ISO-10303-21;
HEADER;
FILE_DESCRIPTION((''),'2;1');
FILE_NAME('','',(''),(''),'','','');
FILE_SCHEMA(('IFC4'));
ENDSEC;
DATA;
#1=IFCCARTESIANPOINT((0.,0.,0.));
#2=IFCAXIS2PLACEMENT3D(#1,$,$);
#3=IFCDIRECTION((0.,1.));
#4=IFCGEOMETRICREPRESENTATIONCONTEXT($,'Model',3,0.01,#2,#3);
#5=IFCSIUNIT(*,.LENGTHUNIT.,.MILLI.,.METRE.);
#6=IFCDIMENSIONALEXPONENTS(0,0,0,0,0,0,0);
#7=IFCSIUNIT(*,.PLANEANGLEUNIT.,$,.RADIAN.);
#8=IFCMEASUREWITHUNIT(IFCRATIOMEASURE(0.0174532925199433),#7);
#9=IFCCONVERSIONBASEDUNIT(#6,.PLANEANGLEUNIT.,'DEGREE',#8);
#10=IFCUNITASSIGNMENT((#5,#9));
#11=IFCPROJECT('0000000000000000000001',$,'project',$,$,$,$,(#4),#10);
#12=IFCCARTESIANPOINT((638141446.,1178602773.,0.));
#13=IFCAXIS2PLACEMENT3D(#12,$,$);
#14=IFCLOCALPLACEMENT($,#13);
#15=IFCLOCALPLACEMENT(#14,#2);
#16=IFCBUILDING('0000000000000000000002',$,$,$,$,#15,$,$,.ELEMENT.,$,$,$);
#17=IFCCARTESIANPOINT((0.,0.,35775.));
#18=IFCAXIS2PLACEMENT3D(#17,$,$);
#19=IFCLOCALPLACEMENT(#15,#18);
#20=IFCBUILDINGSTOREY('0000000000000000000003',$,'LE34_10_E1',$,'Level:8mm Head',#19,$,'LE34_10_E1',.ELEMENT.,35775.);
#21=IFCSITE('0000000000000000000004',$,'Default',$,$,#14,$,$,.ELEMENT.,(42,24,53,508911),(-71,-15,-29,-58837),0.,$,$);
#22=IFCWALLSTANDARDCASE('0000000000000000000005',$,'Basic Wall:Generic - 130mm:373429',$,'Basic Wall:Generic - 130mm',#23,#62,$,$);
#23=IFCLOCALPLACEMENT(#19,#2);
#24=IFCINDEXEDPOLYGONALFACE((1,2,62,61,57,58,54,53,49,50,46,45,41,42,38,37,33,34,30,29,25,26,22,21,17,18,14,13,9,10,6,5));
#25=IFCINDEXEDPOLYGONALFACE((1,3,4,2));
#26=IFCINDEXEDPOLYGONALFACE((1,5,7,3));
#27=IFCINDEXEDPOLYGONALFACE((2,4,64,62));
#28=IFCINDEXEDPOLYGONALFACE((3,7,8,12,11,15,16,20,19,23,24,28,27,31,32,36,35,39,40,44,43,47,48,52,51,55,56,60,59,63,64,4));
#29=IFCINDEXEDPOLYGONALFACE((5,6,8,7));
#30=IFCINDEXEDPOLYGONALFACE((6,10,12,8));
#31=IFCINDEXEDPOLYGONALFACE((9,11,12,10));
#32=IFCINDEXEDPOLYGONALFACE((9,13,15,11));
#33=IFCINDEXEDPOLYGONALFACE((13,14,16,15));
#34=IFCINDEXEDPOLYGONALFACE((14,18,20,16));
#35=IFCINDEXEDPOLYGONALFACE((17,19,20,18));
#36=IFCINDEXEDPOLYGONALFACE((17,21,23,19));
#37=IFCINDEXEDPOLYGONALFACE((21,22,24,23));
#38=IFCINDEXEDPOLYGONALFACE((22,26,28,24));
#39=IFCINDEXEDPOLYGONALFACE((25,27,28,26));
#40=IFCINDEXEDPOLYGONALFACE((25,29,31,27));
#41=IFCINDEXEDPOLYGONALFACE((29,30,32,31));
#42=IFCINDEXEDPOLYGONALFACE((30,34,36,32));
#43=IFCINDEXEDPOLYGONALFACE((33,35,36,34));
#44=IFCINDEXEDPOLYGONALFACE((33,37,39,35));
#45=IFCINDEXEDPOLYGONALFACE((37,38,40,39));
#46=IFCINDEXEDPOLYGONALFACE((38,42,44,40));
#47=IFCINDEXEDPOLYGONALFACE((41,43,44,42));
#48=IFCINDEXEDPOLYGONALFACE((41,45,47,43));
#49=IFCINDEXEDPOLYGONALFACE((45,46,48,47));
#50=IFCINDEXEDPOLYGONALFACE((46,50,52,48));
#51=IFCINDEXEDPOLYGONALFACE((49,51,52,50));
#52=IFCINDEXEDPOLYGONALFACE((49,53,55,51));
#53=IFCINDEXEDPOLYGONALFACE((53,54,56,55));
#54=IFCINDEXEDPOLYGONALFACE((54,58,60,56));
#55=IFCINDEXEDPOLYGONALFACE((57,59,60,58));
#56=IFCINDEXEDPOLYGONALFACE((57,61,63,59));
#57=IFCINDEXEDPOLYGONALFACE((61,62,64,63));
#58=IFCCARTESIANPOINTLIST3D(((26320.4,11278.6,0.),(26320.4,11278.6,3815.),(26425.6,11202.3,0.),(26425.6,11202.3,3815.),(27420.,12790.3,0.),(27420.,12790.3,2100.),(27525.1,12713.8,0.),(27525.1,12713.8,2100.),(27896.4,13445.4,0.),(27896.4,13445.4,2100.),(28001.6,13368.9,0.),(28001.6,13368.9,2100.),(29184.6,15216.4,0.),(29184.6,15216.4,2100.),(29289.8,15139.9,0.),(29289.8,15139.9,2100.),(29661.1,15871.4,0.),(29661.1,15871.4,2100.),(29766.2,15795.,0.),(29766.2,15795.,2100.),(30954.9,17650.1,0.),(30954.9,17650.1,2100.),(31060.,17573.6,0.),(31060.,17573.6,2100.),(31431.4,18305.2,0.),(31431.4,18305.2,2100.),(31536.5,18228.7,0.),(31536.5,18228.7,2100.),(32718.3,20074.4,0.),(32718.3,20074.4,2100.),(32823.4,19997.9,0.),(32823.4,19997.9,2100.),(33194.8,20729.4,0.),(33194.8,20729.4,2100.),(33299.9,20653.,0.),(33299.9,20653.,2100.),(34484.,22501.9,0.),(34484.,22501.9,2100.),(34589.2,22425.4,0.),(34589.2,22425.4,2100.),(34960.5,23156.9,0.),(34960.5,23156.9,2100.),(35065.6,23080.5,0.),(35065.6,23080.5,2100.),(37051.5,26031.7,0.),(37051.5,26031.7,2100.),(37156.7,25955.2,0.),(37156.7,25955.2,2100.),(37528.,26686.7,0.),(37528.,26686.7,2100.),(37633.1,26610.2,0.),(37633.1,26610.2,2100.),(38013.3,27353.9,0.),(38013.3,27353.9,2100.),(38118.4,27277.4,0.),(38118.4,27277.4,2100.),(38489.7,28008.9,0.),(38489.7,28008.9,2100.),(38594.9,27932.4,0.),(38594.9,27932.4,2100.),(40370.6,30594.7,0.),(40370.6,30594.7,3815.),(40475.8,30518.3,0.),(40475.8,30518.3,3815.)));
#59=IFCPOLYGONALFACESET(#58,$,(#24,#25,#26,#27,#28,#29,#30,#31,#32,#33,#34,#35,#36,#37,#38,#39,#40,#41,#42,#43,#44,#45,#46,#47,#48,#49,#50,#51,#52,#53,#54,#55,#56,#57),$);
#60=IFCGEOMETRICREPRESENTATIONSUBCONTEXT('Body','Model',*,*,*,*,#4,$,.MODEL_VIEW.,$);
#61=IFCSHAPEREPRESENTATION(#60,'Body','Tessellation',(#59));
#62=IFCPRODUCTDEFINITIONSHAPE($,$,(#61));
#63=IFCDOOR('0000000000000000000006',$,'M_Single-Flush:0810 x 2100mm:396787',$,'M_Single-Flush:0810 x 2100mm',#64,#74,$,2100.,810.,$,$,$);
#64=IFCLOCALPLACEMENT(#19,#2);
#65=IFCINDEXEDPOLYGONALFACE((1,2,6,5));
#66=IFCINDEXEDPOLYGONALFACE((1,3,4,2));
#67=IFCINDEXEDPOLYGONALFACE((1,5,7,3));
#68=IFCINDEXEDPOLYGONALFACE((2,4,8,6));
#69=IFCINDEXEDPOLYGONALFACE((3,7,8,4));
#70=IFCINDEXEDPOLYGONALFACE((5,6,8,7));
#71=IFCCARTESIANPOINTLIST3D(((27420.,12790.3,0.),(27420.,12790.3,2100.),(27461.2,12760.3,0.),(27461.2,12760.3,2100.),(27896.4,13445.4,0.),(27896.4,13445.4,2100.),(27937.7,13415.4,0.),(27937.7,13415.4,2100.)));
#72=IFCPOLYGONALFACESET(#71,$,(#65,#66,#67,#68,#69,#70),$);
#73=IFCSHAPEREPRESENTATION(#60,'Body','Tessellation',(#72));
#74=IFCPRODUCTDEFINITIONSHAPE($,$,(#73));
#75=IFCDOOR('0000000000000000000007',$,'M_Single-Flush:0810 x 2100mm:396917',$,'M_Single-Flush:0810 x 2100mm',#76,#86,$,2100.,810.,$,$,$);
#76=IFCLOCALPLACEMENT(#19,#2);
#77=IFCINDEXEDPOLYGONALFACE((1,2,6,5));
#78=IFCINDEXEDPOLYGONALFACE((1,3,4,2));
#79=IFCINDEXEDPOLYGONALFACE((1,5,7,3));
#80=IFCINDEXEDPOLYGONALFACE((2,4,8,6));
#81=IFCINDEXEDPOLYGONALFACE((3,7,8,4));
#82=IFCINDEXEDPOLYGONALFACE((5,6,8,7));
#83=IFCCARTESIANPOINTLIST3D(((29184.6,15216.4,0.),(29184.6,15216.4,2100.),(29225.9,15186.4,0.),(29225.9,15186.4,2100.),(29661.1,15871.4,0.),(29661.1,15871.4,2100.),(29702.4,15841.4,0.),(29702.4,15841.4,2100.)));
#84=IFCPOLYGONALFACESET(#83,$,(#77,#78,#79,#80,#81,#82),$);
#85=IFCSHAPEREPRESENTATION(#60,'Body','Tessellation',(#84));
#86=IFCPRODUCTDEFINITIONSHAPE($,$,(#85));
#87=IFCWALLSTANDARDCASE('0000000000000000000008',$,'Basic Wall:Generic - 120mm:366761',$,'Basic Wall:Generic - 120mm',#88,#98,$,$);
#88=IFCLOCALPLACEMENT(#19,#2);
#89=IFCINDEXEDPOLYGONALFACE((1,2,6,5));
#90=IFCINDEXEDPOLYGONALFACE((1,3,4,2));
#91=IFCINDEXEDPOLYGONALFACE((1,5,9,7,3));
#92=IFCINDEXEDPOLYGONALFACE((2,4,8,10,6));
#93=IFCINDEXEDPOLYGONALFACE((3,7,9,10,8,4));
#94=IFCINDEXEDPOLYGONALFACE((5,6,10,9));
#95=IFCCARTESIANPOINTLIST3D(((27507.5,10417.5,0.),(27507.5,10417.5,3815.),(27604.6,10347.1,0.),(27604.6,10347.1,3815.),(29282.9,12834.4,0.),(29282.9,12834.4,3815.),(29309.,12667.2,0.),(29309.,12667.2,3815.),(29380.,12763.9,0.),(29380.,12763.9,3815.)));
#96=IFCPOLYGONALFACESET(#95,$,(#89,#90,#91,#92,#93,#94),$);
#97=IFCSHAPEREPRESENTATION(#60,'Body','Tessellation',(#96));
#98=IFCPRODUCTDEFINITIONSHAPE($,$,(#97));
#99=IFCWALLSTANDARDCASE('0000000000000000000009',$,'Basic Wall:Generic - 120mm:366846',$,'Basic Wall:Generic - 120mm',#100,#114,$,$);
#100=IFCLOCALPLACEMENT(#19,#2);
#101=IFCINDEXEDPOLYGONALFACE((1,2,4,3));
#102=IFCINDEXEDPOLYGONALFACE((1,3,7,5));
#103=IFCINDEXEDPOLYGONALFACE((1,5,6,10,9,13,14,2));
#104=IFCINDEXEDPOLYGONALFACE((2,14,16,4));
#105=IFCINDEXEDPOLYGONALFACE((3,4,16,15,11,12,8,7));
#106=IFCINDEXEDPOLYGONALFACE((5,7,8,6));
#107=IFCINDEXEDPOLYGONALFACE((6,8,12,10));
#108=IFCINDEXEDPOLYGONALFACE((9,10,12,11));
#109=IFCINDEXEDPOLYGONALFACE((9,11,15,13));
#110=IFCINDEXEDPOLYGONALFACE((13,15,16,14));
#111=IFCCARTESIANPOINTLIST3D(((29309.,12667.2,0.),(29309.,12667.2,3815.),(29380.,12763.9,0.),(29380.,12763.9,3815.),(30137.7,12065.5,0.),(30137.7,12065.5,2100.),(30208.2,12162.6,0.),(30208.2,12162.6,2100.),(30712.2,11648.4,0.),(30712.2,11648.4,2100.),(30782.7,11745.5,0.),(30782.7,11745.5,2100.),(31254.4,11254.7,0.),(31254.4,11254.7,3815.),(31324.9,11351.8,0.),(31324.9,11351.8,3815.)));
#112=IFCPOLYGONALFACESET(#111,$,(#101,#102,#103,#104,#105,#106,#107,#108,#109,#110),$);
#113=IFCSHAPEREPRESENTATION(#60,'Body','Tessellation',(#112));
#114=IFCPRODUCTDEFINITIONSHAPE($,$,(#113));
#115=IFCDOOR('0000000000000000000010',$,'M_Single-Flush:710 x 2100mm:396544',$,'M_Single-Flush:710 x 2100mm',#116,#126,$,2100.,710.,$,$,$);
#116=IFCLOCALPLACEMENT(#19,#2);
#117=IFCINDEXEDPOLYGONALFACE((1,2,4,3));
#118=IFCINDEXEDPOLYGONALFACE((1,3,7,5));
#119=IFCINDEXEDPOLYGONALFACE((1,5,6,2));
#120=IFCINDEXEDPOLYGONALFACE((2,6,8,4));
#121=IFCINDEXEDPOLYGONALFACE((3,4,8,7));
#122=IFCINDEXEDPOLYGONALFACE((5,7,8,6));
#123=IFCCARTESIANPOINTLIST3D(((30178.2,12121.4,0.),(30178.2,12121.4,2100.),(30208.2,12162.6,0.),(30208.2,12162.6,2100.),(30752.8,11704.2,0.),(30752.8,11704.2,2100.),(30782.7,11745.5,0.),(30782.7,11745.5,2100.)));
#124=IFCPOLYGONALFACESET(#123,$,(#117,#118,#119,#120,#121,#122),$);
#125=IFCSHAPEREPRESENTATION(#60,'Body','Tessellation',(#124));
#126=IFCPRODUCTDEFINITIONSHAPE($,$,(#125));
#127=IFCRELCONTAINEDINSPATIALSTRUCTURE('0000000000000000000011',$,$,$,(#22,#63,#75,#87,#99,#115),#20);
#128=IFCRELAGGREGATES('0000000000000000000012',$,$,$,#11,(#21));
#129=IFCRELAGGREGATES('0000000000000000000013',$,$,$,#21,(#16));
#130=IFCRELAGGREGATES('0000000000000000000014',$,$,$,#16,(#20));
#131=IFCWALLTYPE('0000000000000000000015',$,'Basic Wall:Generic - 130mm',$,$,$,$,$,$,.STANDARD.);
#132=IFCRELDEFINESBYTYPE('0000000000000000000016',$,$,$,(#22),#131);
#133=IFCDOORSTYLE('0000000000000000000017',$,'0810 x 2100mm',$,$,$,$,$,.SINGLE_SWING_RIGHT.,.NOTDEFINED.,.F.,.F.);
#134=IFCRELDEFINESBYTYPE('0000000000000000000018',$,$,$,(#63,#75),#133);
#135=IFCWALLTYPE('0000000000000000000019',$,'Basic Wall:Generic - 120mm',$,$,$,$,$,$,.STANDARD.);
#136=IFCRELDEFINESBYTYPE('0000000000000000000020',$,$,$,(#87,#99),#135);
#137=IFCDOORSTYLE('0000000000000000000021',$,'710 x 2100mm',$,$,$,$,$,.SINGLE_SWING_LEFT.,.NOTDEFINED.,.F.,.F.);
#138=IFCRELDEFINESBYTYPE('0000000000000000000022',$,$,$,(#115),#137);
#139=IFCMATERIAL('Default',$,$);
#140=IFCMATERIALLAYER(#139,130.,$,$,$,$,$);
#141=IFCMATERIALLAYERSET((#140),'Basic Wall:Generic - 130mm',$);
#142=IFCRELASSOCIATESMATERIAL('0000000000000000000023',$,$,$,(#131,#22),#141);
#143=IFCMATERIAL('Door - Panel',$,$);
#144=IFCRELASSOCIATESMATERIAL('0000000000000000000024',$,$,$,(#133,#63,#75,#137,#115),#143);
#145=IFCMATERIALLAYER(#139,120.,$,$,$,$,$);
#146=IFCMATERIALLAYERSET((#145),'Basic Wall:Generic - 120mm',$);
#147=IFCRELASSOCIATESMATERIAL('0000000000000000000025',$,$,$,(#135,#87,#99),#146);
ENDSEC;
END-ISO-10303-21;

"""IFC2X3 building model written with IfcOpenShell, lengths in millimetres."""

from ifc_helpers import new_model, entity, si_unit, converted_unit, direction, frame, frame_2d, origin, place, context, subcontext, project, spatial, polyline, rectangle, outline, extrude, source, transform, mapped, material, layer, layer_set, layer_usage, type_object, type_shapes, element, fill, save


model = new_model("IFC2X3")

# Units and contexts
model_context = context("Model", 3, precision=0.01, world=origin(), true_north=direction((0.0, 1.0)))
body_context = subcontext(model_context, "Body", "Model", "MODEL_VIEW")
ifc_project = project(units=[si_unit("LENGTHUNIT", "METRE", prefix="MILLI"), converted_unit("PLANEANGLEUNIT", "DEGREE", entity("IfcRatioMeasure", 0.0174532925199433), si_unit("PLANEANGLEUNIT", "RADIAN"), dimensions=[0, 0, 0, 0, 0, 0, 0])], contexts=[model_context])

# Site, building, storey
site_placement = place(None, frame((638141446.0, 1178602773.0, 0.0)))
site = spatial("IfcSite", under=ifc_project, at=site_placement, Name="Default", CompositionType="ELEMENT", RefLatitude=(42, 24, 53, 508911), RefLongitude=(-71, -15, -29, -58837), RefElevation=0.0)
building_placement = place(site_placement, origin())
building = spatial("IfcBuilding", under=site, at=building_placement, CompositionType="ELEMENT")
storey_placement = place(building_placement, frame((0.0, 0.0, 35775.0)))
storey = spatial("IfcBuildingStorey", under=building, at=storey_placement, Name="LE34_10_E1", ObjectType="Level:8mm Head", LongName="LE34_10_E1", CompositionType="ELEMENT", Elevation=35775.0)

# Shared definitions
ifc_material_1 = material(Name="Default")
ifc_material_2 = material(Name="Door - Panel")

# Wall, openings, doors
ifc_layer_1 = layer(ifc_material_1, 130.0)
ifc_layer_set_1 = layer_set([ifc_layer_1], Name="Basic Wall:Generic - 130mm")
ifc_layer_usage_1 = layer_usage(ifc_layer_set_1, "AXIS2", "NEGATIVE", 65.0)
wall_type_1 = type_object("IfcWallType", Name="Basic Wall:Generic - 130mm", PredefinedType="STANDARD", material=ifc_layer_set_1)
wall_1_placement = place(storey_placement, frame((26372.9, 11240.4, 0.0), z_axis=(0.0, 0.0, 1.0), x_axis=(0.588231, 0.808693, 0.0)))
wall_1 = element("IfcWallStandardCase", 1, at=wall_1_placement, inside=storey, type_object=wall_type_1, material=ifc_layer_usage_1, Name="Basic Wall:Generic - 130mm:373429", ObjectType="Basic Wall:Generic - 130mm", context=body_context, shape_type="SweptSolid", body=[
    extrude(outline(polyline([(0.2, -65.0), (23885.6, -65.0), (23885.6, 65.0), (5999.3, 65.0), (5879.3, 65.0), (0.0, 65.0), (0.2, -65.0)])), origin(), (0.0, 0.0, 1.0), 3815.0),
])
opening_1_placement = place(wall_1_placement, frame((1869.3, -65.0, 0.0)))
opening_1 = element("IfcOpeningElement", 2, at=opening_1_placement, cuts=wall_1, ObjectType="Opening", context=body_context, shape_type="SweptSolid", body=[
    extrude(rectangle(XDim=810.0, YDim=2100.0, at=frame_2d((1050.0, 405.0), x_axis=(0.0, 1.0))), frame((0.0, 0.0, 0.0), z_axis=(0.0, 1.0, 0.0), x_axis=(0.0, 0.0, 1.0)), (0.0, 0.0, 1.0), 130.0),
])
opening_2_placement = place(wall_1_placement, frame((4869.3, -65.0, 0.0)))
opening_2 = element("IfcOpeningElement", 3, at=opening_2_placement, cuts=wall_1, ObjectType="Opening", context=body_context, shape_type="SweptSolid", body=[
    extrude(rectangle(XDim=810.0, YDim=2100.0, at=frame_2d((1050.0, 405.0), x_axis=(0.0, 1.0))), frame((0.0, 0.0, 0.0), z_axis=(0.0, 1.0, 0.0), x_axis=(0.0, 0.0, 1.0)), (0.0, 0.0, 1.0), 130.0),
])
opening_3_placement = place(wall_1_placement, frame((-24603.4, 14715.7, 0.0), z_axis=(0.0, 0.0, 1.0), x_axis=(0.588231, -0.808693, 0.0)))
element("IfcOpeningElement", 4, at=opening_3_placement, cuts=wall_1, ObjectType="Opening", context=body_context, shape_type="SweptSolid", body=[
    extrude(rectangle(XDim=2100.0, YDim=810.0, at=frame_2d((0.0, 0.0), x_axis=(1.0, 0.0))), frame((32530.7, 17004.7, 1050.0), z_axis=(-0.808693, 0.588231, 0.0), x_axis=(0.0, 0.0, 1.0)), (0.0, 0.0, 1.0), 3048.0),
])
opening_4_placement = place(wall_1_placement, frame((-24603.4, 14715.7, 0.0), z_axis=(0.0, 0.0, 1.0), x_axis=(0.588231, -0.808693, 0.0)))
element("IfcOpeningElement", 5, at=opening_4_placement, cuts=wall_1, ObjectType="Opening", context=body_context, shape_type="SweptSolid", body=[
    extrude(rectangle(XDim=2100.0, YDim=810.0, at=frame_2d((0.0, 0.0), x_axis=(1.0, 0.0))), frame((34294.1, 19429.0, 1050.0), z_axis=(-0.808693, 0.588231, 0.0), x_axis=(0.0, 0.0, 1.0)), (0.0, 0.0, 1.0), 3048.0),
])
opening_5_placement = place(wall_1_placement, frame((-24603.4, 14715.7, 0.0), z_axis=(0.0, 0.0, 1.0), x_axis=(0.588231, -0.808693, 0.0)))
element("IfcOpeningElement", 6, at=opening_5_placement, cuts=wall_1, ObjectType="Opening", context=body_context, shape_type="SweptSolid", body=[
    extrude(rectangle(XDim=2100.0, YDim=810.0, at=frame_2d((0.0, 0.0), x_axis=(1.0, 0.0))), frame((36059.8, 21856.5, 1050.0), z_axis=(-0.808693, 0.588231, 0.0), x_axis=(0.0, 0.0, 1.0)), (0.0, 0.0, 1.0), 3048.0),
])
opening_6_placement = place(wall_1_placement, frame((-24603.4, 14715.7, 0.0), z_axis=(0.0, 0.0, 1.0), x_axis=(0.588231, -0.808693, 0.0)))
element("IfcOpeningElement", 7, at=opening_6_placement, cuts=wall_1, ObjectType="Opening", context=body_context, shape_type="SweptSolid", body=[
    extrude(rectangle(XDim=2100.0, YDim=810.0, at=frame_2d((0.0, 0.0), x_axis=(1.0, 0.0))), frame((38627.3, 25386.2, 1050.0), z_axis=(-0.808693, 0.588231, 0.0), x_axis=(0.0, 0.0, 1.0)), (0.0, 0.0, 1.0), 3048.0),
])
opening_7_placement = place(wall_1_placement, frame((-24603.4, 14715.7, 0.0), z_axis=(0.0, 0.0, 1.0), x_axis=(0.588231, -0.808693, 0.0)))
element("IfcOpeningElement", 8, at=opening_7_placement, cuts=wall_1, ObjectType="Opening", context=body_context, shape_type="SweptSolid", body=[
    extrude(rectangle(XDim=2100.0, YDim=810.0, at=frame_2d((0.0, 0.0), x_axis=(0.0, 1.0))), frame((39589.1, 26708.5, 1050.0), z_axis=(-0.808693, 0.588231, 0.0), x_axis=(-0.588231, -0.808693, 0.0)), (0.0, 0.0, 1.0), 3048.0),
])
door_style_1 = type_object("IfcDoorStyle", Name="0810 x 2100mm", ConstructionType="NOTDEFINED", OperationType="SINGLE_SWING_RIGHT", ParameterTakesPrecedence=False, Sizeable=False, material=ifc_material_2)
shared_shape_1 = source(origin(), body_context, "Body", "SweptSolid", [
    extrude(rectangle(XDim=51.0, YDim=810.0, at=frame_2d((0.0, 0.0), x_axis=(1.0, 0.0))), frame((405.0, 104.5, 0.0), z_axis=(0.0, 0.0, 1.0), x_axis=(0.0, 1.0, 0.0)), (0.0, 0.0, 1.0), 2100.0),
])
type_shapes(door_style_1, [shared_shape_1])
door_1_placement = place(opening_1_placement, origin())
door_1 = element("IfcDoor", 9, at=door_1_placement, inside=storey, type_object=door_style_1, material=ifc_material_2, Name="M_Single-Flush:0810 x 2100mm:396787", ObjectType="M_Single-Flush:0810 x 2100mm", OverallHeight=2100.0, OverallWidth=810.0, context=body_context, shape_type="MappedRepresentation", body=[
    mapped(shared_shape_1, transform((0.0, 0.0, 0.0), scale=1.0)),
])
fill(opening_1, door_1)
door_2_placement = place(opening_2_placement, origin())
door_2 = element("IfcDoor", 10, at=door_2_placement, inside=storey, type_object=door_style_1, material=ifc_material_2, Name="M_Single-Flush:0810 x 2100mm:396917", ObjectType="M_Single-Flush:0810 x 2100mm", OverallHeight=2100.0, OverallWidth=810.0, context=body_context, shape_type="MappedRepresentation", body=[
    mapped(shared_shape_1, transform((0.0, 0.0, 0.0), scale=1.0)),
])
fill(opening_2, door_2)

# Wall
ifc_layer_2 = layer(ifc_material_1, 120.0)
ifc_layer_set_2 = layer_set([ifc_layer_2], Name="Basic Wall:Generic - 120mm")
ifc_layer_usage_2 = layer_usage(ifc_layer_set_2, "AXIS2", "NEGATIVE", 60.0)
wall_type_2 = type_object("IfcWallType", Name="Basic Wall:Generic - 120mm", PredefinedType="STANDARD", material=ifc_layer_set_2)
wall_2_placement = place(storey_placement, frame((27555.8, 10382.0, 0.0), z_axis=(0.0, 0.0, 1.0), x_axis=(0.592029, 0.805916, 0.0)))
element("IfcWallStandardCase", 11, at=wall_2_placement, inside=storey, type_object=wall_type_2, material=ifc_layer_usage_2, Name="Basic Wall:Generic - 120mm:366761", ObjectType="Basic Wall:Generic - 120mm", context=body_context, shape_type="SweptSolid", body=[
    extrude(outline(polyline([(2999.6, -60.0), (2998.9, 60.0), (0.0, 60.0), (0.7, -60.0), (2879.6, -60.0), (2999.6, -60.0)])), origin(), (0.0, 0.0, 1.0), 3815.0),
])

# Wall, opening, door
ifc_layer_usage_3 = layer_usage(ifc_layer_set_2, "AXIS2", "NEGATIVE", 60.0)
wall_3_placement = place(storey_placement, frame((29344.2, 12715.7, 0.0), z_axis=(0.0, 0.0, 1.0), x_axis=(0.809204, -0.587528, 0.0)))
wall_3 = element("IfcWallStandardCase", 12, at=wall_3_placement, inside=storey, type_object=wall_type_2, material=ifc_layer_usage_3, Name="Basic Wall:Generic - 120mm:366846", ObjectType="Basic Wall:Generic - 120mm", context=body_context, shape_type="SweptSolid", body=[
    extrude(outline(polyline([(0.0, -60.0), (2404.1, -60.0), (2404.1, 60.0), (383.7, 60.0), (243.7, 60.0), (0.7, 60.0), (0.0, -60.0)])), origin(), (0.0, 0.0, 1.0), 3815.0),
])
opening_8_placement = place(wall_3_placement, frame((1024.1, -60.0, 0.0)))
opening_8 = element("IfcOpeningElement", 13, at=opening_8_placement, cuts=wall_3, ObjectType="Opening", context=body_context, shape_type="SweptSolid", body=[
    extrude(rectangle(XDim=710.0, YDim=2100.0, at=frame_2d((1050.0, 355.0), x_axis=(0.0, -1.0))), frame((0.0, 0.0, 0.0), z_axis=(0.0, 1.0, 0.0), x_axis=(0.0, 0.0, 1.0)), (0.0, 0.0, 1.0), 120.0),
])
door_style_2 = type_object("IfcDoorStyle", Name="710 x 2100mm", ConstructionType="NOTDEFINED", OperationType="SINGLE_SWING_LEFT", ParameterTakesPrecedence=False, Sizeable=False, material=ifc_material_2)
shared_shape_2 = source(origin(), body_context, "Body", "SweptSolid", [
    extrude(rectangle(XDim=710.0, YDim=51.0, at=frame_2d((0.0, 0.0), x_axis=(1.0, 0.0))), frame((355.0, 94.5, 0.0)), (0.0, 0.0, 1.0), 2100.0),
])
type_shapes(door_style_2, [shared_shape_2])
door_3_placement = place(opening_8_placement, origin())
door_3 = element("IfcDoor", 14, at=door_3_placement, inside=storey, type_object=door_style_2, material=ifc_material_2, Name="M_Single-Flush:710 x 2100mm:396544", ObjectType="M_Single-Flush:710 x 2100mm", OverallHeight=2100.0, OverallWidth=710.0, context=body_context, shape_type="MappedRepresentation", body=[
    mapped(shared_shape_2, transform((0.0, 0.0, 0.0), scale=1.0)),
])
fill(opening_8, door_3)

save(model, "model.ifc")
